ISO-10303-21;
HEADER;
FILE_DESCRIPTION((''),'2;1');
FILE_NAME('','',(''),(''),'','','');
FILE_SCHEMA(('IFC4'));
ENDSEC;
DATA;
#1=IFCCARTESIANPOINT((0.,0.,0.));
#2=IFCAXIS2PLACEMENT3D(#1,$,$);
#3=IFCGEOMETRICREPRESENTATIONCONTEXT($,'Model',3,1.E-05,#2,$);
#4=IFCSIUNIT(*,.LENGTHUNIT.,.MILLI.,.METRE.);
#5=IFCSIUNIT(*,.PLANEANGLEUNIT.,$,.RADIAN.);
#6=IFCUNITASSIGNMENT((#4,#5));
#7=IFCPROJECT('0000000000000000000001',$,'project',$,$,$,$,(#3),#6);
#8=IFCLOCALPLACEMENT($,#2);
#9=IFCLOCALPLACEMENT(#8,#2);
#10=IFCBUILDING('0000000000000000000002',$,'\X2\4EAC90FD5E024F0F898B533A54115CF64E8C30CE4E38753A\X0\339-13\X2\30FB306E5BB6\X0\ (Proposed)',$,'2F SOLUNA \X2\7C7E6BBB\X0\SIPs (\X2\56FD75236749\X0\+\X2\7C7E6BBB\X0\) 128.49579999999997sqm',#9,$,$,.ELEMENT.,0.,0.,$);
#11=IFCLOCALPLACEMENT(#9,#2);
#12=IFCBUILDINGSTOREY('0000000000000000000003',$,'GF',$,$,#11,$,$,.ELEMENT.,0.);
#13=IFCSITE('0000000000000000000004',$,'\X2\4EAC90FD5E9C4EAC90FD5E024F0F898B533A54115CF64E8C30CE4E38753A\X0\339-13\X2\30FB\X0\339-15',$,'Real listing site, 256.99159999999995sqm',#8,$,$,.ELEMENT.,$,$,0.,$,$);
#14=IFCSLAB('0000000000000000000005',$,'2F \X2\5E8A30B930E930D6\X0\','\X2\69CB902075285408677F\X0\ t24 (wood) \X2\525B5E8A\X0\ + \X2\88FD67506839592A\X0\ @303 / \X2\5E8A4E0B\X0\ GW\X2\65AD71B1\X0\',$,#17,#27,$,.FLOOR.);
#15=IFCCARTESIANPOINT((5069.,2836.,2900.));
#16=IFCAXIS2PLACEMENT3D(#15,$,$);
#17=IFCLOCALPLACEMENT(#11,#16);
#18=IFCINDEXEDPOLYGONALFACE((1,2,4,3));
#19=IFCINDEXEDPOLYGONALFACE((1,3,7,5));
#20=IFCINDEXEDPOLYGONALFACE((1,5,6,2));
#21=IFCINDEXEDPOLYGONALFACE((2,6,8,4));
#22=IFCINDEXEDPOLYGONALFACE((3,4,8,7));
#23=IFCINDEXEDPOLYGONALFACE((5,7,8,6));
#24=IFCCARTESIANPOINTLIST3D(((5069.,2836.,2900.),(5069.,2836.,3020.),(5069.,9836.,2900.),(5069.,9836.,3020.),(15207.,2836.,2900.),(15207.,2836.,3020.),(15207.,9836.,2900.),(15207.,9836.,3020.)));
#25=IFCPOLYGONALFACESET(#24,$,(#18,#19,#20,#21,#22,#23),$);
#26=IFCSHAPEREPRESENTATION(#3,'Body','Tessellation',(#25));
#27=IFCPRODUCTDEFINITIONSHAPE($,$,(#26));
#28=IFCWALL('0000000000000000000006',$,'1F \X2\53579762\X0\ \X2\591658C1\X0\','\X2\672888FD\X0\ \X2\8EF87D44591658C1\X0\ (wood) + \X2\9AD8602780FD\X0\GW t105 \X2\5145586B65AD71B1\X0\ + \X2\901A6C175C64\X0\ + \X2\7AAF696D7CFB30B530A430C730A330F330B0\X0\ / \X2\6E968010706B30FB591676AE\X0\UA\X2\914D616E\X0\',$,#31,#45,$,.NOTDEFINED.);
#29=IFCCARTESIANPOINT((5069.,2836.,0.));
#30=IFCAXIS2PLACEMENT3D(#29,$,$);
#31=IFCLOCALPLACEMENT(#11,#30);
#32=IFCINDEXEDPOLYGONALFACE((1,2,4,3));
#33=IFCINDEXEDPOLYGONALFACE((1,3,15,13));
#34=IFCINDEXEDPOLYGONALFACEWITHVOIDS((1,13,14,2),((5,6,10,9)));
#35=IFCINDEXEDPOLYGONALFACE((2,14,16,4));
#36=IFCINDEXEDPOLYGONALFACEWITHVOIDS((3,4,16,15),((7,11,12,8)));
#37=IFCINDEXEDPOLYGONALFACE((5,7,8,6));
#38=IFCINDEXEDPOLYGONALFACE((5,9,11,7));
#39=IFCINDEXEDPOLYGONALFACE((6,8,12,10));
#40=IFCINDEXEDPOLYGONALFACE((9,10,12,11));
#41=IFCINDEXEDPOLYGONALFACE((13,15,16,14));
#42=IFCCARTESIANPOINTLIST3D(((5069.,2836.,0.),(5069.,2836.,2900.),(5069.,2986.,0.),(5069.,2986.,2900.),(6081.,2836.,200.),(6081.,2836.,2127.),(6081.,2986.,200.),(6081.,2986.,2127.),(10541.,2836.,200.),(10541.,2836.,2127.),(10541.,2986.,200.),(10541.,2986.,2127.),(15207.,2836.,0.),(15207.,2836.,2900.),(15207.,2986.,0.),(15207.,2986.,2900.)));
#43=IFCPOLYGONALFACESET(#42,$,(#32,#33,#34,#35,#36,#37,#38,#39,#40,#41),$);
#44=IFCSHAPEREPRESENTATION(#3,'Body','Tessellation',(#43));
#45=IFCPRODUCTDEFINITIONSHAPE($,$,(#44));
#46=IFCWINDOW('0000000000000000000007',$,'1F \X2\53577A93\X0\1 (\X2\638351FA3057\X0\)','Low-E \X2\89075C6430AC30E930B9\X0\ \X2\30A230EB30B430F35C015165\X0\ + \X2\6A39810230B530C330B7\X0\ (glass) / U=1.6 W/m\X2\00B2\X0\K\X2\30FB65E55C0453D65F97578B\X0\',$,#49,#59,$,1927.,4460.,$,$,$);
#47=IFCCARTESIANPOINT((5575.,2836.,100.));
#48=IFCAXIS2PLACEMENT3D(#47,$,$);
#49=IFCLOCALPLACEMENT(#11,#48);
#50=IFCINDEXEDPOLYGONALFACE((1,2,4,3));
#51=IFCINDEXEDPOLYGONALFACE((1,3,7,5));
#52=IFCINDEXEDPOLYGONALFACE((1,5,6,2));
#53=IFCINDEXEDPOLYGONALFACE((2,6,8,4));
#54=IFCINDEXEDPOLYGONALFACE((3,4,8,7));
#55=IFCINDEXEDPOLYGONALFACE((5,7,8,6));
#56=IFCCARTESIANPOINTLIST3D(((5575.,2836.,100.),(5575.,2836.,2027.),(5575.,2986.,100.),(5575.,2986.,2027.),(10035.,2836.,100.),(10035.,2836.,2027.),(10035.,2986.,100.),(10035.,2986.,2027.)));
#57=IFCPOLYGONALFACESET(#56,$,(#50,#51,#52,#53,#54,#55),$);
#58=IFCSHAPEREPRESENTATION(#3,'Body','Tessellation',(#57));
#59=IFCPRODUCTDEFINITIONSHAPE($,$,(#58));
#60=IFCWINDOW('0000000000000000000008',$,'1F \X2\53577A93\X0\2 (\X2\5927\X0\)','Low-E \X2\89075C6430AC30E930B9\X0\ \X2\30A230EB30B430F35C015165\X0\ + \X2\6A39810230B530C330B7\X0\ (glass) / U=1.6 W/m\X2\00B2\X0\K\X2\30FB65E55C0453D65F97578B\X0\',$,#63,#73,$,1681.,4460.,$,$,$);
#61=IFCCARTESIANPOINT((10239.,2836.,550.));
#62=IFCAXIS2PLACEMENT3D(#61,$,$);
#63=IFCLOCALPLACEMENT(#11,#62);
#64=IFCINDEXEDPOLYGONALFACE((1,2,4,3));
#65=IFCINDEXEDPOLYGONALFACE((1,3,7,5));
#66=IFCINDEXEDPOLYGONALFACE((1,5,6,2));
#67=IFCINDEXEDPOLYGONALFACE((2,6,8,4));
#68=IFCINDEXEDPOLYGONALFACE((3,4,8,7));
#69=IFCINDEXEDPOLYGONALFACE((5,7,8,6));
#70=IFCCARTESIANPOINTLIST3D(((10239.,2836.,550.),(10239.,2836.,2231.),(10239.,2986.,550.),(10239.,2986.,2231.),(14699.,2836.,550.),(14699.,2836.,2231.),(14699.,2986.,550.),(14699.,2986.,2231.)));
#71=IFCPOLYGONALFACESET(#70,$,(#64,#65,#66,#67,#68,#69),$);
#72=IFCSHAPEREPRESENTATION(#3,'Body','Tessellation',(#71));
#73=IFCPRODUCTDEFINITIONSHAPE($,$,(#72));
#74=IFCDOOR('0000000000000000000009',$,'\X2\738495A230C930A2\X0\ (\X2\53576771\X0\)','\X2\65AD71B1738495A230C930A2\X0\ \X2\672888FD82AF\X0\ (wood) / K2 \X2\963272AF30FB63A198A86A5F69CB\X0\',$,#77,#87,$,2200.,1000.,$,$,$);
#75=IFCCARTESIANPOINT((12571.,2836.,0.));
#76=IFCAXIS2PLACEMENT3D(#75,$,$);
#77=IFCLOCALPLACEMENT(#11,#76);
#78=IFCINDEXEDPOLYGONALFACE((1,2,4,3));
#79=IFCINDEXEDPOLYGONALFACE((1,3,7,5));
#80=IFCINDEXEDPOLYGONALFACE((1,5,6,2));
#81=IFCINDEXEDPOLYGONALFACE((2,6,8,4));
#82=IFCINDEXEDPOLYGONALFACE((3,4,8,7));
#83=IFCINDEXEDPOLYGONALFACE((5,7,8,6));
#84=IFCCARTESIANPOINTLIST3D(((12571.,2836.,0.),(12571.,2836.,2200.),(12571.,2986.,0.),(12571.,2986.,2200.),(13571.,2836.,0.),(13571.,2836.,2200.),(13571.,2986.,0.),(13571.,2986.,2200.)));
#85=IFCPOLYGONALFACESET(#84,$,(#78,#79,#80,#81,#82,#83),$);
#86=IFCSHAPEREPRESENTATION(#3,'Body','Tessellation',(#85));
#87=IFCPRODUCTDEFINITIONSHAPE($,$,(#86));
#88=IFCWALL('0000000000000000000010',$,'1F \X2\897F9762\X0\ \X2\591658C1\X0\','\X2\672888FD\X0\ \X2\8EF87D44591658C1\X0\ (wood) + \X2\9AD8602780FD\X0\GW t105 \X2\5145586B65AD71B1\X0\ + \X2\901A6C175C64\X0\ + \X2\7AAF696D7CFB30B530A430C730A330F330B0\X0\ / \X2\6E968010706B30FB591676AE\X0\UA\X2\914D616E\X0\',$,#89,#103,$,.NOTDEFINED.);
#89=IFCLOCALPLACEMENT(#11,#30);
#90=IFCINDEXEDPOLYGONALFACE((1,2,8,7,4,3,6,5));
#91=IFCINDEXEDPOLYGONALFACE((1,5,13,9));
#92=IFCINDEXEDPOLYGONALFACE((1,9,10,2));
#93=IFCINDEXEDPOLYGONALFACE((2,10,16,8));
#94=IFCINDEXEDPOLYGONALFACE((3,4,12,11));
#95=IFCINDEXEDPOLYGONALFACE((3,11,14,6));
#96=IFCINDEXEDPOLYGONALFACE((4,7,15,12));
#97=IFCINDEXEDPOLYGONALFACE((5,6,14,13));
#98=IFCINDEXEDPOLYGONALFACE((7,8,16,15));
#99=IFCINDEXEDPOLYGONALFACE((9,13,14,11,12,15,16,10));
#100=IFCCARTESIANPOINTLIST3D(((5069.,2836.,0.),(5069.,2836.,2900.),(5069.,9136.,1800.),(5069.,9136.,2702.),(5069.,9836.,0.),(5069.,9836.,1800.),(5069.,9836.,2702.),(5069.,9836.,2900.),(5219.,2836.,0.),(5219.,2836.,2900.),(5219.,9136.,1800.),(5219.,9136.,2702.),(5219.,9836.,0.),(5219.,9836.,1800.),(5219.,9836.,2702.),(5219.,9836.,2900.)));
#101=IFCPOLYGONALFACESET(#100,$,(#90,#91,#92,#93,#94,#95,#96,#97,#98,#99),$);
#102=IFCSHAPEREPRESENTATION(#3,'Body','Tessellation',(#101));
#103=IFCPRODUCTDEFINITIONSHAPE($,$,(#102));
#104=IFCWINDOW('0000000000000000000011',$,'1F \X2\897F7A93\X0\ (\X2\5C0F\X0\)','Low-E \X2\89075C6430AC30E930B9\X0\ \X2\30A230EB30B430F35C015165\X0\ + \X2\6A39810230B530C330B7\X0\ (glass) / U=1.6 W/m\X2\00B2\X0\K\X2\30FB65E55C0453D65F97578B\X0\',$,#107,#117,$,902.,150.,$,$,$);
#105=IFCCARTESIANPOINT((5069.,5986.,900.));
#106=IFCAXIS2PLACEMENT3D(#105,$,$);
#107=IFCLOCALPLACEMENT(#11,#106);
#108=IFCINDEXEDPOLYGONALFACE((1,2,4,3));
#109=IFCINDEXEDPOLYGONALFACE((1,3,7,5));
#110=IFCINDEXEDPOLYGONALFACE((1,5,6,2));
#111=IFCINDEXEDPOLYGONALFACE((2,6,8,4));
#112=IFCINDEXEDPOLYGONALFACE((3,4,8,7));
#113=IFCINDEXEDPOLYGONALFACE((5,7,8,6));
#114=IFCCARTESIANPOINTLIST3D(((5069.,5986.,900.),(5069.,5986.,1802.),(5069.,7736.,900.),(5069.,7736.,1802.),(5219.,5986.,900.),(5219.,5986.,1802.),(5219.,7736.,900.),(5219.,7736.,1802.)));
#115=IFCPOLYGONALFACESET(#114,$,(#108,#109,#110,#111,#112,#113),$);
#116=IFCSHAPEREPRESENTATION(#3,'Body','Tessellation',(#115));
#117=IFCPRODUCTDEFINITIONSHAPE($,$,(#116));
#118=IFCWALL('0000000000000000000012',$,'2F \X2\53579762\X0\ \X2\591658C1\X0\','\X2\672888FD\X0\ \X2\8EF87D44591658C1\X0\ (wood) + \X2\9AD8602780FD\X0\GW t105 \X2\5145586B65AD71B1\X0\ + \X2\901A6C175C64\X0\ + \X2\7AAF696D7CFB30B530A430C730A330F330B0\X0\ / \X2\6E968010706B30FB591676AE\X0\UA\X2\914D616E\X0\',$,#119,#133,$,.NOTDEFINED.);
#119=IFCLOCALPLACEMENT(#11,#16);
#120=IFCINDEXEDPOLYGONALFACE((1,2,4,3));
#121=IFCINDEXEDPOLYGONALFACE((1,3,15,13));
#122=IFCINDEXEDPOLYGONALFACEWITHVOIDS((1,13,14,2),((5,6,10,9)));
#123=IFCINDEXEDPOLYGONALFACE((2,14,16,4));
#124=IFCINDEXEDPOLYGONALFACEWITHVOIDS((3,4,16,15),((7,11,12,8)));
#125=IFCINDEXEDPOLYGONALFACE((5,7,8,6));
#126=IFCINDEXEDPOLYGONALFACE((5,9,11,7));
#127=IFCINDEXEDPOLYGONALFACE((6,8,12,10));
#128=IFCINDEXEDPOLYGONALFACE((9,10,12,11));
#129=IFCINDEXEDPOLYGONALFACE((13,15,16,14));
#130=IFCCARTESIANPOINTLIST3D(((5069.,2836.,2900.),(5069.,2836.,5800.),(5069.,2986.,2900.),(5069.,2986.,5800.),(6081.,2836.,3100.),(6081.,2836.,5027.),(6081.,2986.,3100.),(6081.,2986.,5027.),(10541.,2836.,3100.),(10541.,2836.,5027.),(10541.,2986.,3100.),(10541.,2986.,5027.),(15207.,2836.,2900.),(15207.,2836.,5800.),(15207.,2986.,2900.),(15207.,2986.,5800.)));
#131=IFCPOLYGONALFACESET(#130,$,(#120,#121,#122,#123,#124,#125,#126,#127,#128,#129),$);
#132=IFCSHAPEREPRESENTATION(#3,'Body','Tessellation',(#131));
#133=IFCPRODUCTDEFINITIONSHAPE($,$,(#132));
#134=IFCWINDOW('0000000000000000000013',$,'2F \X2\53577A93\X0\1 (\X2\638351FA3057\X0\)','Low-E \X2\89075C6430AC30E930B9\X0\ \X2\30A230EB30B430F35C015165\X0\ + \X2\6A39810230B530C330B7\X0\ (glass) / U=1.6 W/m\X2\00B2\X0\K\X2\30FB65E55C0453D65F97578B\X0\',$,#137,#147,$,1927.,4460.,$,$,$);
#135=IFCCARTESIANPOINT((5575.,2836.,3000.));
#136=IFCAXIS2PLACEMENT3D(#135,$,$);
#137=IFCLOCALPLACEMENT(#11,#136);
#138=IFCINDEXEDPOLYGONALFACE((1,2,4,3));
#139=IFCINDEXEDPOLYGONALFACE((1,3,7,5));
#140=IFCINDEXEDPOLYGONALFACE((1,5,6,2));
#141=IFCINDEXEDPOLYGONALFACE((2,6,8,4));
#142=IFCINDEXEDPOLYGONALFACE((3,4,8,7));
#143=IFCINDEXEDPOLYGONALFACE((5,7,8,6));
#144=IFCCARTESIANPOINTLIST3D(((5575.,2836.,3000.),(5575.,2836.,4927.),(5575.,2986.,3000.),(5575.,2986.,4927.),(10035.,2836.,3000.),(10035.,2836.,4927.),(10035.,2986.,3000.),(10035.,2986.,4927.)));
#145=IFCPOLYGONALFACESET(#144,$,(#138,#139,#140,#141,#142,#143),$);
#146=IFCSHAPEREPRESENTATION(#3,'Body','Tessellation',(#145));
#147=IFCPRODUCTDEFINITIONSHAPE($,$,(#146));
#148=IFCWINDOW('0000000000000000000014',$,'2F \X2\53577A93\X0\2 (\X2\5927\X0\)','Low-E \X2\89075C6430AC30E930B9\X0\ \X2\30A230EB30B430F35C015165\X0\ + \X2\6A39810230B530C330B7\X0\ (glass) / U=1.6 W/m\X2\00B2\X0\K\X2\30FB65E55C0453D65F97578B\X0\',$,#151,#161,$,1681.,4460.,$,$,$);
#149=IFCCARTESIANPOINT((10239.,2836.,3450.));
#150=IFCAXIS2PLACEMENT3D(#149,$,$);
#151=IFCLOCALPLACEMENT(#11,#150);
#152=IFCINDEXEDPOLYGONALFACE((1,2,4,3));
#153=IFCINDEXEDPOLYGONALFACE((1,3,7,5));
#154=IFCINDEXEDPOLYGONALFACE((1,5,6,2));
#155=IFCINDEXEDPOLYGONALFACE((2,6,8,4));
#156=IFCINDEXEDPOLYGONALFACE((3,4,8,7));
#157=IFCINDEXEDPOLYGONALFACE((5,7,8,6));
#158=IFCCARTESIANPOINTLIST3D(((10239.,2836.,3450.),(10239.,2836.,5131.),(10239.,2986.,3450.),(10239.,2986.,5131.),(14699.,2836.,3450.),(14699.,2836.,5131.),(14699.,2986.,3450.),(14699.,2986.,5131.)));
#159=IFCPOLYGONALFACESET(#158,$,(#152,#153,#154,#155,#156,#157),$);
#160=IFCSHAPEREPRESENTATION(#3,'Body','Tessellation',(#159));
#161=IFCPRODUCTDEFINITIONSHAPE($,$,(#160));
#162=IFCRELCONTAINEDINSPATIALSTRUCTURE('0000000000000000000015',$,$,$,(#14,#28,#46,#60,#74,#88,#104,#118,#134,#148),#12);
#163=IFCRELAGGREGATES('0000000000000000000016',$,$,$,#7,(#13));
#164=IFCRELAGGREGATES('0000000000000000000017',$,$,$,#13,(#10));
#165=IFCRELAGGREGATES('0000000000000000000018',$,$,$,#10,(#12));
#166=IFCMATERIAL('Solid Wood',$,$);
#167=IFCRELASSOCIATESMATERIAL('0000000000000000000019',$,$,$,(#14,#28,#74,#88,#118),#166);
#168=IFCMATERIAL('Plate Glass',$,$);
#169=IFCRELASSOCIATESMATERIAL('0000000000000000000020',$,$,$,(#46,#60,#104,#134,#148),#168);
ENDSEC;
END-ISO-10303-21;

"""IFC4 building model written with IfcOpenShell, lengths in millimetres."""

from ifc_helpers import new_model, si_unit, frame, frame_2d, origin, place, context, project, spatial, rectangle, extrude, material, element, fill, save


model = new_model("IFC4")

# Units and contexts
model_context = context("Model", 3, precision=1e-05, world=origin())
ifc_project = project(units=[si_unit("LENGTHUNIT", "METRE", prefix="MILLI"), si_unit("PLANEANGLEUNIT", "RADIAN")], contexts=[model_context])

# Site, building, storey
site_placement = place(None, origin())
site = spatial("IfcSite", under=ifc_project, at=site_placement, Name="京都府京都市伏見区向島二ノ丸町339-13・339-15", ObjectType="Real listing site, 256.99159999999995sqm", CompositionType="ELEMENT", RefElevation=0.0)
building_placement = place(site_placement, origin())
building = spatial("IfcBuilding", under=site, at=building_placement, Name="京都市伏見区向島二ノ丸町339-13・の家 (Proposed)", ObjectType="2F SOLUNA 籾殻SIPs (国産杉+籾殻) 128.49579999999997sqm", CompositionType="ELEMENT", ElevationOfRefHeight=0.0, ElevationOfTerrain=0.0)
storey_placement = place(building_placement, origin())
storey = spatial("IfcBuildingStorey", under=building, at=storey_placement, Name="GF", CompositionType="ELEMENT", Elevation=0.0)

# Slab
ifc_material_1 = material(Name="Solid Wood")
slab_1_placement = place(storey_placement, frame((5069.0, 2836.0, 2900.0)))
element("IfcSlab", 1, at=slab_1_placement, inside=storey, material=ifc_material_1, Name="2F 床スラブ", Description="構造用合板 t24 (wood) 剛床 + 製材根太 @303 / 床下 GW断熱", PredefinedType="FLOOR", context=model_context, shape_type="SweptSolid", body=[
    extrude(rectangle(XDim=10138.0, YDim=7000.0, at=frame_2d((5069.0, 3500.0))), frame((5069.0, 2836.0, 2900.0)), (0.0, 0.0, 1.0), 120.0),
])

# Wall, openings, windows, door
wall_1_placement = place(storey_placement, frame((5069.0, 2836.0, 0.0)))
wall_1 = element("IfcWall", 2, at=wall_1_placement, inside=storey, material=ifc_material_1, Name="1F 南面 外壁", Description="木製 軸組外壁 (wood) + 高性能GW t105 充填断熱 + 通気層 + 窯業系サイディング / 準耐火・外皮UA配慮", PredefinedType="NOTDEFINED", context=model_context, shape_type="SweptSolid", body=[
    extrude(rectangle(XDim=10138.0, YDim=150.0, at=frame_2d((5069.0, 75.0))), frame((5069.0, 2836.0, 0.0)), (0.0, 0.0, 1.0), 2900.0),
])
opening_1_placement = place(storey_placement, frame((5575.0, 2836.0, 100.0)))
opening_1 = element("IfcOpeningElement", 3, at=opening_1_placement, cuts=wall_1, PredefinedType="NOTDEFINED", context=model_context, shape_type="SweptSolid", body=[
    extrude(rectangle(XDim=4460.0, YDim=150.0, at=frame_2d((2230.0, 75.0))), frame((5575.0, 2836.0, 100.0)), (0.0, 0.0, 1.0), 1927.0),
])
opening_2_placement = place(storey_placement, frame((10239.0, 2836.0, 550.0)))
opening_2 = element("IfcOpeningElement", 4, at=opening_2_placement, cuts=wall_1, PredefinedType="NOTDEFINED", context=model_context, shape_type="SweptSolid", body=[
    extrude(rectangle(XDim=4460.0, YDim=150.0, at=frame_2d((2230.0, 75.0))), frame((10239.0, 2836.0, 550.0)), (0.0, 0.0, 1.0), 1681.0),
])
opening_3_placement = place(storey_placement, frame((12571.0, 2836.0, 0.0)))
opening_3 = element("IfcOpeningElement", 5, at=opening_3_placement, cuts=wall_1, PredefinedType="NOTDEFINED", context=model_context, shape_type="SweptSolid", body=[
    extrude(rectangle(XDim=1000.0, YDim=150.0, at=frame_2d((500.0, 75.0))), frame((12571.0, 2836.0, 0.0)), (0.0, 0.0, 1.0), 2200.0),
])
ifc_material_2 = material(Name="Plate Glass")
window_1_placement = place(storey_placement, frame((5575.0, 2836.0, 100.0)))
window_1 = element("IfcWindow", 6, at=window_1_placement, inside=storey, material=ifc_material_2, Name="1F 南窓1 (掃出し)", Description="Low-E 複層ガラス アルゴン封入 + 樹脂サッシ (glass) / U=1.6 W/m²K・日射取得型", OverallHeight=1927.0, OverallWidth=4460.0, context=model_context, shape_type="SweptSolid", body=[
    extrude(rectangle(XDim=4460.0, YDim=150.0, at=frame_2d((2230.0, 75.0))), frame((5575.0, 2836.0, 100.0)), (0.0, 0.0, 1.0), 1927.0),
])
fill(opening_1, window_1)
window_2_placement = place(storey_placement, frame((10239.0, 2836.0, 550.0)))
window_2 = element("IfcWindow", 7, at=window_2_placement, inside=storey, material=ifc_material_2, Name="1F 南窓2 (大)", Description="Low-E 複層ガラス アルゴン封入 + 樹脂サッシ (glass) / U=1.6 W/m²K・日射取得型", OverallHeight=1681.0, OverallWidth=4460.0, context=model_context, shape_type="SweptSolid", body=[
    extrude(rectangle(XDim=4460.0, YDim=150.0, at=frame_2d((2230.0, 75.0))), frame((10239.0, 2836.0, 550.0)), (0.0, 0.0, 1.0), 1681.0),
])
fill(opening_2, window_2)
door_placement = place(storey_placement, frame((12571.0, 2836.0, 0.0)))
door = element("IfcDoor", 8, at=door_placement, inside=storey, material=ifc_material_1, Name="玄関ドア (南東)", Description="断熱玄関ドア 木製芯 (wood) / K2 防犯・採風機構", OverallHeight=2200.0, OverallWidth=1000.0, context=model_context, shape_type="SweptSolid", body=[
    extrude(rectangle(XDim=1000.0, YDim=150.0, at=frame_2d((500.0, 75.0))), frame((12571.0, 2836.0, 0.0)), (0.0, 0.0, 1.0), 2200.0),
])
fill(opening_3, door)

# Wall, opening, window
wall_2_placement = place(storey_placement, frame((5069.0, 2836.0, 0.0)))
wall_2 = element("IfcWall", 9, at=wall_2_placement, inside=storey, material=ifc_material_1, Name="1F 西面 外壁", Description="木製 軸組外壁 (wood) + 高性能GW t105 充填断熱 + 通気層 + 窯業系サイディング / 準耐火・外皮UA配慮", PredefinedType="NOTDEFINED", context=model_context, shape_type="SweptSolid", body=[
    extrude(rectangle(XDim=150.0, YDim=7000.0, at=frame_2d((75.0, 3500.0))), frame((5069.0, 2836.0, 0.0)), (0.0, 0.0, 1.0), 2900.0),
])
opening_4_placement = place(storey_placement, frame((5069.0, 5986.0, 900.0)))
opening_4 = element("IfcOpeningElement", 10, at=opening_4_placement, cuts=wall_2, PredefinedType="NOTDEFINED", context=model_context, shape_type="SweptSolid", body=[
    extrude(rectangle(XDim=150.0, YDim=1750.0, at=frame_2d((75.0, 875.0))), frame((5069.0, 5986.0, 900.0)), (0.0, 0.0, 1.0), 902.0),
])
window_3_placement = place(storey_placement, frame((5069.0, 5986.0, 900.0)))
window_3 = element("IfcWindow", 11, at=window_3_placement, inside=storey, material=ifc_material_2, Name="1F 西窓 (小)", Description="Low-E 複層ガラス アルゴン封入 + 樹脂サッシ (glass) / U=1.6 W/m²K・日射取得型", OverallHeight=902.0, OverallWidth=150.0, context=model_context, shape_type="SweptSolid", body=[
    extrude(rectangle(XDim=150.0, YDim=1750.0, at=frame_2d((75.0, 875.0))), frame((5069.0, 5986.0, 900.0)), (0.0, 0.0, 1.0), 902.0),
])
fill(opening_4, window_3)

# Wall, openings, windows
wall_3_placement = place(storey_placement, frame((5069.0, 2836.0, 2900.0)))
wall_3 = element("IfcWall", 12, at=wall_3_placement, inside=storey, material=ifc_material_1, Name="2F 南面 外壁", Description="木製 軸組外壁 (wood) + 高性能GW t105 充填断熱 + 通気層 + 窯業系サイディング / 準耐火・外皮UA配慮", PredefinedType="NOTDEFINED", context=model_context, shape_type="SweptSolid", body=[
    extrude(rectangle(XDim=10138.0, YDim=150.0, at=frame_2d((5069.0, 75.0))), frame((5069.0, 2836.0, 2900.0)), (0.0, 0.0, 1.0), 2900.0),
])
opening_5_placement = place(storey_placement, frame((5575.0, 2836.0, 3000.0)))
opening_5 = element("IfcOpeningElement", 13, at=opening_5_placement, cuts=wall_3, PredefinedType="NOTDEFINED", context=model_context, shape_type="SweptSolid", body=[
    extrude(rectangle(XDim=4460.0, YDim=150.0, at=frame_2d((2230.0, 75.0))), frame((5575.0, 2836.0, 3000.0)), (0.0, 0.0, 1.0), 1927.0),
])
opening_6_placement = place(storey_placement, frame((10239.0, 2836.0, 3450.0)))
opening_6 = element("IfcOpeningElement", 14, at=opening_6_placement, cuts=wall_3, PredefinedType="NOTDEFINED", context=model_context, shape_type="SweptSolid", body=[
    extrude(rectangle(XDim=4460.0, YDim=150.0, at=frame_2d((2230.0, 75.0))), frame((10239.0, 2836.0, 3450.0)), (0.0, 0.0, 1.0), 1681.0),
])
window_4_placement = place(storey_placement, frame((5575.0, 2836.0, 3000.0)))
window_4 = element("IfcWindow", 15, at=window_4_placement, inside=storey, material=ifc_material_2, Name="2F 南窓1 (掃出し)", Description="Low-E 複層ガラス アルゴン封入 + 樹脂サッシ (glass) / U=1.6 W/m²K・日射取得型", OverallHeight=1927.0, OverallWidth=4460.0, context=model_context, shape_type="SweptSolid", body=[
    extrude(rectangle(XDim=4460.0, YDim=150.0, at=frame_2d((2230.0, 75.0))), frame((5575.0, 2836.0, 3000.0)), (0.0, 0.0, 1.0), 1927.0),
])
fill(opening_5, window_4)
window_5_placement = place(storey_placement, frame((10239.0, 2836.0, 3450.0)))
window_5 = element("IfcWindow", 16, at=window_5_placement, inside=storey, material=ifc_material_2, Name="2F 南窓2 (大)", Description="Low-E 複層ガラス アルゴン封入 + 樹脂サッシ (glass) / U=1.6 W/m²K・日射取得型", OverallHeight=1681.0, OverallWidth=4460.0, context=model_context, shape_type="SweptSolid", body=[
    extrude(rectangle(XDim=4460.0, YDim=150.0, at=frame_2d((2230.0, 75.0))), frame((10239.0, 2836.0, 3450.0)), (0.0, 0.0, 1.0), 1681.0),
])
fill(opening_6, window_5)

save(model, "model.ifc")
